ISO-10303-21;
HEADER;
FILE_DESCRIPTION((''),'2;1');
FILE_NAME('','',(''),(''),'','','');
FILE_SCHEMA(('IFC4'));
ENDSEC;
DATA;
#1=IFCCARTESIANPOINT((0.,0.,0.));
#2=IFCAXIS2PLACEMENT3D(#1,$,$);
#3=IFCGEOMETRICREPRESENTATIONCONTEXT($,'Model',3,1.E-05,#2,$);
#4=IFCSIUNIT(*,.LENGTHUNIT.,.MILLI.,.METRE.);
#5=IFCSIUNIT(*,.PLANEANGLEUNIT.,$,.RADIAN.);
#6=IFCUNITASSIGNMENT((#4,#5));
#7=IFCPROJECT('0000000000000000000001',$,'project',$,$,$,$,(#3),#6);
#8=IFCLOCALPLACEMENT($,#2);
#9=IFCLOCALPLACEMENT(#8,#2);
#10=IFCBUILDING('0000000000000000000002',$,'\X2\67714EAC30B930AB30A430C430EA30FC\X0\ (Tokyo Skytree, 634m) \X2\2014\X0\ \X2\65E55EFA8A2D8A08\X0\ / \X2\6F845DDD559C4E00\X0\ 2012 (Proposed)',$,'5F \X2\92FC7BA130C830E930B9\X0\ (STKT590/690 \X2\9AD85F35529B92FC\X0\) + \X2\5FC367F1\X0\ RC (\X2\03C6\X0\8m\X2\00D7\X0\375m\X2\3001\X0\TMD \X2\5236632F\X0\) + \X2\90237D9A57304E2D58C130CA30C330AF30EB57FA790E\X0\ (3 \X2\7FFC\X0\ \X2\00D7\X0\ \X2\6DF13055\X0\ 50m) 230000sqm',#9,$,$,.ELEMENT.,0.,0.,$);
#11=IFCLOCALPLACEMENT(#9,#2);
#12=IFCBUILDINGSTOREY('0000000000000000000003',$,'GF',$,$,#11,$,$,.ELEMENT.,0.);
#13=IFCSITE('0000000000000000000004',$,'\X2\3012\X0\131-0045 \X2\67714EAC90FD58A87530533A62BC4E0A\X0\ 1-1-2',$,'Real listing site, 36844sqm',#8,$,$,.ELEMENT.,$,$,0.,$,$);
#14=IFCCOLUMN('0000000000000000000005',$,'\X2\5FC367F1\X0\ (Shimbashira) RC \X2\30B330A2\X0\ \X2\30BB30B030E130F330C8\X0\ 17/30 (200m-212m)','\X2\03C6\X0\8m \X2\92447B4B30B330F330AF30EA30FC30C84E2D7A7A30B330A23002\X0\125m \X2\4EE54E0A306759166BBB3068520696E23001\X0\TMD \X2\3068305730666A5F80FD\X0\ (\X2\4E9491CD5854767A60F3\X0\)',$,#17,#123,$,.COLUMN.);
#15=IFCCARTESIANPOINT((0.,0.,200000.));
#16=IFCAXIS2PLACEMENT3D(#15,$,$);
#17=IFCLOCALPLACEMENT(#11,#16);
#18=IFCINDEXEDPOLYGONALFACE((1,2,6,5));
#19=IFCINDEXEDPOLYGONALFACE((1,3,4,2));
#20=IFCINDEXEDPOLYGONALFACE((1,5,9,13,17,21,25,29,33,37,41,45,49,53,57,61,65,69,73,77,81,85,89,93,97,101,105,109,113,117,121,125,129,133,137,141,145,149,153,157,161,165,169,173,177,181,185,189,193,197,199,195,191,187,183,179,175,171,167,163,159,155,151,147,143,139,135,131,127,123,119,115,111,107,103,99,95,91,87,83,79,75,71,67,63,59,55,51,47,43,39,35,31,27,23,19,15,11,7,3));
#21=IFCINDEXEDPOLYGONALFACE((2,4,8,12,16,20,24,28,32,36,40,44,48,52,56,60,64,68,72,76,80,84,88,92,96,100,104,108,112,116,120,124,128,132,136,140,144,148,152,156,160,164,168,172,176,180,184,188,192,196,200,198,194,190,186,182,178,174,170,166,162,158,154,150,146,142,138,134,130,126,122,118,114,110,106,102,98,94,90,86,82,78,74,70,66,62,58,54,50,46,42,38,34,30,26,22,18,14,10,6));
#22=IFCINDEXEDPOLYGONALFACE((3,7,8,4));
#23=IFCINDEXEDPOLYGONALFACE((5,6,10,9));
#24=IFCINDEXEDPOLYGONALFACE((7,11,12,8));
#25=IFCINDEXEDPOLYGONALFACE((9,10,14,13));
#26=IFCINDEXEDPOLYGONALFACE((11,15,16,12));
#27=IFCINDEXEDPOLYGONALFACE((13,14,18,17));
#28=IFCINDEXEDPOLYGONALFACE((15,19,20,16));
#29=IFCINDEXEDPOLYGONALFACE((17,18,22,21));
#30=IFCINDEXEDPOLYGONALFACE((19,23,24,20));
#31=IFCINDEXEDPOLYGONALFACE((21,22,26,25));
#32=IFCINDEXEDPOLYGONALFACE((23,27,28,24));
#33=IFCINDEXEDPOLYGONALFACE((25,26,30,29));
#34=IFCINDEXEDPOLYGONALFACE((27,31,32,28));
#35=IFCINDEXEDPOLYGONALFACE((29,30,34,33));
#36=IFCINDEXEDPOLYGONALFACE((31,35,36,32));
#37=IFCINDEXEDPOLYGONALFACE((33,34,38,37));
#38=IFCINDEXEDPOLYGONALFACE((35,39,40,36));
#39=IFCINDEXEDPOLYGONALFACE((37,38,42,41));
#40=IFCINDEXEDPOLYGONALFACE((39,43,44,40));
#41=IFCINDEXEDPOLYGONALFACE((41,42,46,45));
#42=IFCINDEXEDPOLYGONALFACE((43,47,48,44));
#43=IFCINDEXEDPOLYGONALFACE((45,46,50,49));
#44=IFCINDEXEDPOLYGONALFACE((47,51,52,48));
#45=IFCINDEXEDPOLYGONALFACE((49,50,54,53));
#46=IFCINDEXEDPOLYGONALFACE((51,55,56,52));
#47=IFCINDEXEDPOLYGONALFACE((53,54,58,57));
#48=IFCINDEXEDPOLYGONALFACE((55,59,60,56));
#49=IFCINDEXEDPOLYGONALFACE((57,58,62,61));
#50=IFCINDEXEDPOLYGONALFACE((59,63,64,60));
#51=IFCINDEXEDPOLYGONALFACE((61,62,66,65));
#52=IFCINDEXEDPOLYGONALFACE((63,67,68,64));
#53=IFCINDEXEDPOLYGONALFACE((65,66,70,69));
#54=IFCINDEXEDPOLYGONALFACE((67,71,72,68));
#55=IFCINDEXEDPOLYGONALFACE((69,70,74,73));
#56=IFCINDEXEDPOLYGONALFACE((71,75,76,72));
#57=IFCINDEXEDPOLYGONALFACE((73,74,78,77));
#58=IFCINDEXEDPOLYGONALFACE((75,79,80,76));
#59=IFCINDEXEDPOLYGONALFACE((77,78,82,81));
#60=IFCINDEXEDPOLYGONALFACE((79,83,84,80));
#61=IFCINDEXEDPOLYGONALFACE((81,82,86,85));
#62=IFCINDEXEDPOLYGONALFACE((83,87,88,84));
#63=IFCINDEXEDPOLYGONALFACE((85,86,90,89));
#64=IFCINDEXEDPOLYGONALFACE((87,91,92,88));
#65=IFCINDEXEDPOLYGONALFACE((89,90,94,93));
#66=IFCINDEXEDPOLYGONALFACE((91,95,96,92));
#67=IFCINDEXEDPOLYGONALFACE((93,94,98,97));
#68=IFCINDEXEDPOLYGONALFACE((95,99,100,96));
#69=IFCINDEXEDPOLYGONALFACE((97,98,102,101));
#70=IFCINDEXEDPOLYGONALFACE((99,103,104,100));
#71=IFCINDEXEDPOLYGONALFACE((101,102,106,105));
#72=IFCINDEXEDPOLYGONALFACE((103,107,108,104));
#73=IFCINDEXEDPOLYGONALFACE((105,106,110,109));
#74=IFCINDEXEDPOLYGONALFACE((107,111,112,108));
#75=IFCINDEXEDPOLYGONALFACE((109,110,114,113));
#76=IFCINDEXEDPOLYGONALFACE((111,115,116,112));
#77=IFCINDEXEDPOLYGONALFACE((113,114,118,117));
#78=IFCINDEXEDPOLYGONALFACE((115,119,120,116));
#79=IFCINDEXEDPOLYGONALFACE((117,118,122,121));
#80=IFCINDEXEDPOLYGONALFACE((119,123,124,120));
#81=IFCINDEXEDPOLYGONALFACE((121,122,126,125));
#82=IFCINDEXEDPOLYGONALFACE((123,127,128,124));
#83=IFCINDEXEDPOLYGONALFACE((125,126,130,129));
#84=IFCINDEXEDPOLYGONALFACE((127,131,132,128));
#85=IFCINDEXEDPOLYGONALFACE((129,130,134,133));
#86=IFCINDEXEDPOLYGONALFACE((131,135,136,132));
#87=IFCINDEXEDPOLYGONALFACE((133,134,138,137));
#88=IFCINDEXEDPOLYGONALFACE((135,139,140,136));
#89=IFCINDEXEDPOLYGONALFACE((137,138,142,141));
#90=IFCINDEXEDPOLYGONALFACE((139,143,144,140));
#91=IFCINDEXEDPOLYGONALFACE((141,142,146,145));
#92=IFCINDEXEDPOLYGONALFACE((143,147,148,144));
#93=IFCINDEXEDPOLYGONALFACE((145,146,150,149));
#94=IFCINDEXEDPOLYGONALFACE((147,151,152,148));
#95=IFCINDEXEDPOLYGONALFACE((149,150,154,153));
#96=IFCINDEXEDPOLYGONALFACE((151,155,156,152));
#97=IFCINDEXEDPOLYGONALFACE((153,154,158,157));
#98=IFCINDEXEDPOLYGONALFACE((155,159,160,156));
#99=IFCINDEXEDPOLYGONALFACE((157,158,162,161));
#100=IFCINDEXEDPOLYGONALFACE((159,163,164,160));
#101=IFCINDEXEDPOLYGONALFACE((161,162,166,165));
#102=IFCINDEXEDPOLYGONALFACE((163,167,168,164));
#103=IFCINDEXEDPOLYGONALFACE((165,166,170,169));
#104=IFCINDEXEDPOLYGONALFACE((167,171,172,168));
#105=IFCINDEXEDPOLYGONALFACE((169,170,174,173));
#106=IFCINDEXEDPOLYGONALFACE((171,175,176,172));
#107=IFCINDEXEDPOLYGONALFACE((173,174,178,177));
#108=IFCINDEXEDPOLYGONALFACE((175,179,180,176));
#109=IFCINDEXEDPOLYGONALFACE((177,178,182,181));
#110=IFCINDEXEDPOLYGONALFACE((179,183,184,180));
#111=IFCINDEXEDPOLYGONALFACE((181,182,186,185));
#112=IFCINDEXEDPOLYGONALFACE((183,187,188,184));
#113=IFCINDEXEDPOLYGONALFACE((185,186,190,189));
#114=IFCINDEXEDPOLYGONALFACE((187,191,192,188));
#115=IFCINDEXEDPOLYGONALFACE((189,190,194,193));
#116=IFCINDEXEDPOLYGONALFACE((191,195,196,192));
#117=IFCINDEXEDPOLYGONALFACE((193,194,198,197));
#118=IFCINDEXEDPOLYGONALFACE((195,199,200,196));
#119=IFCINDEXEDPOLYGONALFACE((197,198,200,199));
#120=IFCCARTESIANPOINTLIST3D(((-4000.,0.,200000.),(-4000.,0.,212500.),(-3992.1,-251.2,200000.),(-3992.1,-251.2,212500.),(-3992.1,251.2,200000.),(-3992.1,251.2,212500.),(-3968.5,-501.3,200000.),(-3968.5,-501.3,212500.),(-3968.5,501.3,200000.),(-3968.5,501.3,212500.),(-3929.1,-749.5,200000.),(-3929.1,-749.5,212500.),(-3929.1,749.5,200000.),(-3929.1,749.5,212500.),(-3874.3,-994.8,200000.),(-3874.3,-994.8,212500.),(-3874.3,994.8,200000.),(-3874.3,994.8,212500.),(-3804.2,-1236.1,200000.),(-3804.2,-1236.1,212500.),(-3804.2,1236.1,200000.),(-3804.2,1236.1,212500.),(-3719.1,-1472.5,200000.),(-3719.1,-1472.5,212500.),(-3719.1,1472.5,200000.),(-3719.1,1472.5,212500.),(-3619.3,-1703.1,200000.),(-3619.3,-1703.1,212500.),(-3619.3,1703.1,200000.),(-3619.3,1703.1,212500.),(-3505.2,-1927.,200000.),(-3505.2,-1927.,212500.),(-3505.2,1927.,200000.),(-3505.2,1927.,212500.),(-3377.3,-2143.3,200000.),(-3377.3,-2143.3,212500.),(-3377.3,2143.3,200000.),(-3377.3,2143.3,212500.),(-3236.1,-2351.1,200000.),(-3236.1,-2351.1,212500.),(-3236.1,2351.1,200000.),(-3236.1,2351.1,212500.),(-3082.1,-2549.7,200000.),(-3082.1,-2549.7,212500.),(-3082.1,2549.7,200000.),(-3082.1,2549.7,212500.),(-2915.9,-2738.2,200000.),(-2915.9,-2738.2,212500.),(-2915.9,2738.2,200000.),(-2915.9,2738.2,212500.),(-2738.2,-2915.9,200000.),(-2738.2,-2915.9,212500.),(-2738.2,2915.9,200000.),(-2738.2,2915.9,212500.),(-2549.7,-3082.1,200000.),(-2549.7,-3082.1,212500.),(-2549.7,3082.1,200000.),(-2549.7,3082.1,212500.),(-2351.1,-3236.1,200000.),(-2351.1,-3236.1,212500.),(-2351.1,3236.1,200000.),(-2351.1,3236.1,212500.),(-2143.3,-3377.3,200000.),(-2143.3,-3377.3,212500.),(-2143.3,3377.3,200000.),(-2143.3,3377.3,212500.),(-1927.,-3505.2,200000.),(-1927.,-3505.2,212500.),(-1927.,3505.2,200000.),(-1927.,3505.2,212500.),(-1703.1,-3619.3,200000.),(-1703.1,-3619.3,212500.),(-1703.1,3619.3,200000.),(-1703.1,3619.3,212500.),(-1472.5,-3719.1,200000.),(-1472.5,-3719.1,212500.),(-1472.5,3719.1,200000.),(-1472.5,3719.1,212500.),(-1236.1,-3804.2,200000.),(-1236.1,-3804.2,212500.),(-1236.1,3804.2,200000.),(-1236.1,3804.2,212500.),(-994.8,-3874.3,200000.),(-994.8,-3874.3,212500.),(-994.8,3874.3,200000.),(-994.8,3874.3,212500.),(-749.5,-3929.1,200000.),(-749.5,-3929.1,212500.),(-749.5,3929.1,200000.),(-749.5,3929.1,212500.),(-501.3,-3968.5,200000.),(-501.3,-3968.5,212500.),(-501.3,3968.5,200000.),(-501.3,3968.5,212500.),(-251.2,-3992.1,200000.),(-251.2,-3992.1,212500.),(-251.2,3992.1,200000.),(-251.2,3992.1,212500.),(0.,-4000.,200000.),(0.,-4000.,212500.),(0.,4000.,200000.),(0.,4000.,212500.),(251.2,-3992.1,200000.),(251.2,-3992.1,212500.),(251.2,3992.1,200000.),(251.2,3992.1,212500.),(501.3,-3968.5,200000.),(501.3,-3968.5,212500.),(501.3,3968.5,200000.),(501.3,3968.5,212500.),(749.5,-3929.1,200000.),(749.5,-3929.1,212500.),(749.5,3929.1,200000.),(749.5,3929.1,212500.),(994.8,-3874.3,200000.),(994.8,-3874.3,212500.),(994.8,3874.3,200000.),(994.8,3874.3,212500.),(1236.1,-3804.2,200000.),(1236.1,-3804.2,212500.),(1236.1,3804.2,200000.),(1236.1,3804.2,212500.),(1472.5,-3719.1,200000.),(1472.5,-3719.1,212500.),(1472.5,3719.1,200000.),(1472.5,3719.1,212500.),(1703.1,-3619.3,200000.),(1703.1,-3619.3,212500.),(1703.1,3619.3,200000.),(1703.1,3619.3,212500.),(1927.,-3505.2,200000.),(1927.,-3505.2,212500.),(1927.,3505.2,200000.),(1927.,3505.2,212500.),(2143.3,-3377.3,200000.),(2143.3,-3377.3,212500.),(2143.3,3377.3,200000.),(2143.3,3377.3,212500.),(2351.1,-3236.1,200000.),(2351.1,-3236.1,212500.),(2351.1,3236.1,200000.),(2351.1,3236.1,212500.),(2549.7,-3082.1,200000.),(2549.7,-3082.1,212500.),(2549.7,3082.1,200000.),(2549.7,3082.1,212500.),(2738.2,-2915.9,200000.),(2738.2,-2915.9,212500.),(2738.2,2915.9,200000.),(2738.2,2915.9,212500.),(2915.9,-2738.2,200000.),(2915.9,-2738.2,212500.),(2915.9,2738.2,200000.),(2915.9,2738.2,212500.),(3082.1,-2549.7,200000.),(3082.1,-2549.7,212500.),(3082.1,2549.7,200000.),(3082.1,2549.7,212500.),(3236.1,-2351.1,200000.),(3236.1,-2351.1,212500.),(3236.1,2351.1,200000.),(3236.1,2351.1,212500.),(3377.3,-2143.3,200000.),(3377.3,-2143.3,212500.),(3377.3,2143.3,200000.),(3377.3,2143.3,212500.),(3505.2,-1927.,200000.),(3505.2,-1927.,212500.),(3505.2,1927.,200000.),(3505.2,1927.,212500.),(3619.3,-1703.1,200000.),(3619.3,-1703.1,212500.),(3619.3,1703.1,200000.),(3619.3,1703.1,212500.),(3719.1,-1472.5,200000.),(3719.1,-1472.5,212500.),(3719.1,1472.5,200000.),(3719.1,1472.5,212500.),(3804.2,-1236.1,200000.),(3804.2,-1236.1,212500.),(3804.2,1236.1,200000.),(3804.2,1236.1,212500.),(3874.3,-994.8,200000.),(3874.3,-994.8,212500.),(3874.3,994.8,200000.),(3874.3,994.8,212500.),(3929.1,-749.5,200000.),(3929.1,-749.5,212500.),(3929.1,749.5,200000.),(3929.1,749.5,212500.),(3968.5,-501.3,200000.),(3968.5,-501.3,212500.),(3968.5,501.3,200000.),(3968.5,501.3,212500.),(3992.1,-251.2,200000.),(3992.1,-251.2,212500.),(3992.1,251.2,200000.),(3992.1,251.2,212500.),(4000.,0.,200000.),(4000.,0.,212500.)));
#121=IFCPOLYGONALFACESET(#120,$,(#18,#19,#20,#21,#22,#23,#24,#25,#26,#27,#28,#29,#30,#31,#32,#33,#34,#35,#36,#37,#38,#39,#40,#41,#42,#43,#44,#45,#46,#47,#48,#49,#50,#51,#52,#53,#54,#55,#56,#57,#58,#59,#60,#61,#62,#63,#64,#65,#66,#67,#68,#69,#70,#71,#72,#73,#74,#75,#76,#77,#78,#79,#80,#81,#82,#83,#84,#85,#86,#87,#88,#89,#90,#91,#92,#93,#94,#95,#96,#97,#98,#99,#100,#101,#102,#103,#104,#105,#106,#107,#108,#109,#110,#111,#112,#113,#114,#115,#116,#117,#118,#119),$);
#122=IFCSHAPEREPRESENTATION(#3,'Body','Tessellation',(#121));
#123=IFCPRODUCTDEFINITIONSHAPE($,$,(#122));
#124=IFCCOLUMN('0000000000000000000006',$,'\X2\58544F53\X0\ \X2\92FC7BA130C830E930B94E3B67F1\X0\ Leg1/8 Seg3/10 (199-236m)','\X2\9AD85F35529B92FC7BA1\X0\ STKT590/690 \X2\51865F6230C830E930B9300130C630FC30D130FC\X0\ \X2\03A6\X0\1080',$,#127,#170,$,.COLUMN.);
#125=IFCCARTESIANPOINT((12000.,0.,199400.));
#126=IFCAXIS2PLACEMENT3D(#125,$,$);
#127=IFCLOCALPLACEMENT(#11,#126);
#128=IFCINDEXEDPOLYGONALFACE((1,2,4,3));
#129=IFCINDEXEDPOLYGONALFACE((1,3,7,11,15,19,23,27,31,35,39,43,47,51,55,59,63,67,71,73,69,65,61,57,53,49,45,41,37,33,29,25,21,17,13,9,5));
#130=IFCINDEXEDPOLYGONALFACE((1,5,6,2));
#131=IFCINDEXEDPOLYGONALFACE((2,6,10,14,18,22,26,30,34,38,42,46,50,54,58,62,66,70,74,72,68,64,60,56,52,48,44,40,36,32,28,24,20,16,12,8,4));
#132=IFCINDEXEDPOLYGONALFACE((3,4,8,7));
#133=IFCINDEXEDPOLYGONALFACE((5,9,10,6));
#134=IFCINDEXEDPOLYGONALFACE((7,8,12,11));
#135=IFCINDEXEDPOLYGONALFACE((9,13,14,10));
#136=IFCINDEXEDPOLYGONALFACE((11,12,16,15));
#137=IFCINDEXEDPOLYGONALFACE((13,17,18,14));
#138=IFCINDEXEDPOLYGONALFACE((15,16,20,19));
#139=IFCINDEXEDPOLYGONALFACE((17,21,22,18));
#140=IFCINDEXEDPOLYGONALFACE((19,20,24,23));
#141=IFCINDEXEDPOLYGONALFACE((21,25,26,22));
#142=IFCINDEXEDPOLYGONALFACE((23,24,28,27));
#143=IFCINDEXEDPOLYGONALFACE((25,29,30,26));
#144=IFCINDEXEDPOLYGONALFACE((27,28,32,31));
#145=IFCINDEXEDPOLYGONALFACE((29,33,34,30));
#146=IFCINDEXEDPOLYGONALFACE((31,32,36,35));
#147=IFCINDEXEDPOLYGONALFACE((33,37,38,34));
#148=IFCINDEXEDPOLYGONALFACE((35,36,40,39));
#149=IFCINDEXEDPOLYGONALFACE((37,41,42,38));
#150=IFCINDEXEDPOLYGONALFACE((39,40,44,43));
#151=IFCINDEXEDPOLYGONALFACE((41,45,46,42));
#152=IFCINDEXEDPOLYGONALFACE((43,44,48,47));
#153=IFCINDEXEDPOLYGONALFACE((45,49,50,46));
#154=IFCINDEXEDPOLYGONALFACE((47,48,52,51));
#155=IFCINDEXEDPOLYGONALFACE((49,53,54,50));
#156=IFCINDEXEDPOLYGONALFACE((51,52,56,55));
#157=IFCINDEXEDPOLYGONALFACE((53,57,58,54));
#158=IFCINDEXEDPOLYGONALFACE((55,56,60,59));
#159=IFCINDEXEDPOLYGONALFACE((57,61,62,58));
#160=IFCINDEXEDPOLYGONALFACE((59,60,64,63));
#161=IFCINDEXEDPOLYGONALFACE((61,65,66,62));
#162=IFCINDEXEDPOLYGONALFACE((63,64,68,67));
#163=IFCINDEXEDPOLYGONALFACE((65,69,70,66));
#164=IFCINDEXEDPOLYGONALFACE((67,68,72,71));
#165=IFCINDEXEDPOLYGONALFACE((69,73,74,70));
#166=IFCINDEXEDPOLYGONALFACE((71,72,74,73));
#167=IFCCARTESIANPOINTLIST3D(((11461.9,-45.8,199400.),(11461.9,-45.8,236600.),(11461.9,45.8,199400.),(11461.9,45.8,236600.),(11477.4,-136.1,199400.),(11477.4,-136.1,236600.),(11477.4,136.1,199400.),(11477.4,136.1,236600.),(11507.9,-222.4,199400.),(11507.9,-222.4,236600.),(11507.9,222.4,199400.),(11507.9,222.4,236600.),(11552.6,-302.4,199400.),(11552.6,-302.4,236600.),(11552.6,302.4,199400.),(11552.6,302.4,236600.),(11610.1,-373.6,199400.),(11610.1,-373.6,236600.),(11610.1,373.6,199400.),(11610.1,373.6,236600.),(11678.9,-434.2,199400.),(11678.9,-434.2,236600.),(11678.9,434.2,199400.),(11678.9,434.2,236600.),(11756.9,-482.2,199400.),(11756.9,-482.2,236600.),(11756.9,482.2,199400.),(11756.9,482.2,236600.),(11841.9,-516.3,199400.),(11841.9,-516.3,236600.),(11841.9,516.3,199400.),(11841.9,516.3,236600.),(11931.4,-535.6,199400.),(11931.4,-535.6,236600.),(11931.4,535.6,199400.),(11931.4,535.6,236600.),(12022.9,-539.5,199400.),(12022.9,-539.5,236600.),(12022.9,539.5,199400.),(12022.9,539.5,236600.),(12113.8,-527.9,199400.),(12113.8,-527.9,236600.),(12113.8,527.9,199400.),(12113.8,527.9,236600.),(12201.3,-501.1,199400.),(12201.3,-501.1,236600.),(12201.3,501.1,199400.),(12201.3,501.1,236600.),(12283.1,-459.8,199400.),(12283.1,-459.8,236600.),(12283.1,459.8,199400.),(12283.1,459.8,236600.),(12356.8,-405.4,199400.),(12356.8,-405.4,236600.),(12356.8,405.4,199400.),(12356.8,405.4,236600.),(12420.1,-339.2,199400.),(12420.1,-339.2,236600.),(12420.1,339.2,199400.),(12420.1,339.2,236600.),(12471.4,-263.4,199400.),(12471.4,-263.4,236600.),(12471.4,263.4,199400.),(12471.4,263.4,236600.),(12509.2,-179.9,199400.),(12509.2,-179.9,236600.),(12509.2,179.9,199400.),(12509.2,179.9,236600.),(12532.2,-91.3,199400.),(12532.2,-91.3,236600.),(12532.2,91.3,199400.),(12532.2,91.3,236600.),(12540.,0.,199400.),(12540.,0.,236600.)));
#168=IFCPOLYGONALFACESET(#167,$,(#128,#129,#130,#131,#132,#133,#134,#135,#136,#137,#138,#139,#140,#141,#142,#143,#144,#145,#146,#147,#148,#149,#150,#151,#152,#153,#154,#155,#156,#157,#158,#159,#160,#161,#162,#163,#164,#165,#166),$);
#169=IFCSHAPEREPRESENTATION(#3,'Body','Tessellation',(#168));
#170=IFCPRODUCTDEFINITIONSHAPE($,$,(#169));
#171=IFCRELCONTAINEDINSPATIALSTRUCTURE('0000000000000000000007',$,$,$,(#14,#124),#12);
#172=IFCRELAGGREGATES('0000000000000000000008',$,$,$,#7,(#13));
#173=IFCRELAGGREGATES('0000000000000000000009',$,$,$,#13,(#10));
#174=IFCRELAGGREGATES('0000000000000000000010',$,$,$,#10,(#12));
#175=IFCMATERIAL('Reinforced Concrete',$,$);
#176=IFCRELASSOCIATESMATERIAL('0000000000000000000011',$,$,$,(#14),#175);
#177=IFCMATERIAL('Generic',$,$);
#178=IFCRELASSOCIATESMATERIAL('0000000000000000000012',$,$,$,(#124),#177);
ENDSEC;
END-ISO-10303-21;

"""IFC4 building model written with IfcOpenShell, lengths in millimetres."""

from ifc_helpers import new_model, si_unit, frame, origin, origin_2d, place, context, project, spatial, circle, extrude, material, element, save


model = new_model("IFC4")

# Units and contexts
model_context = context("Model", 3, precision=1e-05, world=origin())
ifc_project = project(units=[si_unit("LENGTHUNIT", "METRE", prefix="MILLI"), si_unit("PLANEANGLEUNIT", "RADIAN")], contexts=[model_context])

# Site, building, storey
site_placement = place(None, origin())
site = spatial("IfcSite", under=ifc_project, at=site_placement, Name="〒131-0045 東京都墨田区押上 1-1-2", ObjectType="Real listing site, 36844sqm", CompositionType="ELEMENT", RefElevation=0.0)
building_placement = place(site_placement, origin())
building = spatial("IfcBuilding", under=site, at=building_placement, Name="東京スカイツリー (Tokyo Skytree, 634m) — 日建設計 / 澄川喜一 2012 (Proposed)", ObjectType="5F 鋼管トラス (STKT590/690 高張力鋼) + 心柱 RC (φ8m×375m、TMD 制振) + 連続地中壁ナックル基礎 (3 翼 × 深さ 50m) 230000sqm", CompositionType="ELEMENT", ElevationOfRefHeight=0.0, ElevationOfTerrain=0.0)
storey_placement = place(building_placement, origin())
storey = spatial("IfcBuildingStorey", under=building, at=storey_placement, Name="GF", CompositionType="ELEMENT", Elevation=0.0)

# Columns
ifc_material_1 = material(Name="Reinforced Concrete")
column_1_placement = place(storey_placement, frame((0.0, 0.0, 200000.0)))
element("IfcColumn", 1, at=column_1_placement, inside=storey, material=ifc_material_1, Name="心柱 (Shimbashira) RC コア セグメント 17/30 (200m-212m)", Description="φ8m 鉄筋コンクリート中空コア。125m 以上で外殻と分離、TMD として機能 (五重塔発想)", PredefinedType="COLUMN", context=model_context, shape_type="SweptSolid", body=[
    extrude(circle(Radius=4000.0, at=origin_2d()), frame((0.0, 0.0, 200000.0)), (0.0, 0.0, 1.0), 12500.0),
])
ifc_material_2 = material(Name="Generic")
column_2_placement = place(storey_placement, frame((12000.0, 0.0, 199400.0)))
element("IfcColumn", 2, at=column_2_placement, inside=storey, material=ifc_material_2, Name="塔体 鋼管トラス主柱 Leg1/8 Seg3/10 (199-236m)", Description="高張力鋼管 STKT590/690 円形トラス、テーパー Φ1080", PredefinedType="COLUMN", context=model_context, shape_type="SweptSolid", body=[
    extrude(circle(Radius=540.0, at=origin_2d()), frame((12000.0, 0.0, 199400.0)), (0.0, 0.0, 1.0), 37200.0),
])

save(model, "model.ifc")
